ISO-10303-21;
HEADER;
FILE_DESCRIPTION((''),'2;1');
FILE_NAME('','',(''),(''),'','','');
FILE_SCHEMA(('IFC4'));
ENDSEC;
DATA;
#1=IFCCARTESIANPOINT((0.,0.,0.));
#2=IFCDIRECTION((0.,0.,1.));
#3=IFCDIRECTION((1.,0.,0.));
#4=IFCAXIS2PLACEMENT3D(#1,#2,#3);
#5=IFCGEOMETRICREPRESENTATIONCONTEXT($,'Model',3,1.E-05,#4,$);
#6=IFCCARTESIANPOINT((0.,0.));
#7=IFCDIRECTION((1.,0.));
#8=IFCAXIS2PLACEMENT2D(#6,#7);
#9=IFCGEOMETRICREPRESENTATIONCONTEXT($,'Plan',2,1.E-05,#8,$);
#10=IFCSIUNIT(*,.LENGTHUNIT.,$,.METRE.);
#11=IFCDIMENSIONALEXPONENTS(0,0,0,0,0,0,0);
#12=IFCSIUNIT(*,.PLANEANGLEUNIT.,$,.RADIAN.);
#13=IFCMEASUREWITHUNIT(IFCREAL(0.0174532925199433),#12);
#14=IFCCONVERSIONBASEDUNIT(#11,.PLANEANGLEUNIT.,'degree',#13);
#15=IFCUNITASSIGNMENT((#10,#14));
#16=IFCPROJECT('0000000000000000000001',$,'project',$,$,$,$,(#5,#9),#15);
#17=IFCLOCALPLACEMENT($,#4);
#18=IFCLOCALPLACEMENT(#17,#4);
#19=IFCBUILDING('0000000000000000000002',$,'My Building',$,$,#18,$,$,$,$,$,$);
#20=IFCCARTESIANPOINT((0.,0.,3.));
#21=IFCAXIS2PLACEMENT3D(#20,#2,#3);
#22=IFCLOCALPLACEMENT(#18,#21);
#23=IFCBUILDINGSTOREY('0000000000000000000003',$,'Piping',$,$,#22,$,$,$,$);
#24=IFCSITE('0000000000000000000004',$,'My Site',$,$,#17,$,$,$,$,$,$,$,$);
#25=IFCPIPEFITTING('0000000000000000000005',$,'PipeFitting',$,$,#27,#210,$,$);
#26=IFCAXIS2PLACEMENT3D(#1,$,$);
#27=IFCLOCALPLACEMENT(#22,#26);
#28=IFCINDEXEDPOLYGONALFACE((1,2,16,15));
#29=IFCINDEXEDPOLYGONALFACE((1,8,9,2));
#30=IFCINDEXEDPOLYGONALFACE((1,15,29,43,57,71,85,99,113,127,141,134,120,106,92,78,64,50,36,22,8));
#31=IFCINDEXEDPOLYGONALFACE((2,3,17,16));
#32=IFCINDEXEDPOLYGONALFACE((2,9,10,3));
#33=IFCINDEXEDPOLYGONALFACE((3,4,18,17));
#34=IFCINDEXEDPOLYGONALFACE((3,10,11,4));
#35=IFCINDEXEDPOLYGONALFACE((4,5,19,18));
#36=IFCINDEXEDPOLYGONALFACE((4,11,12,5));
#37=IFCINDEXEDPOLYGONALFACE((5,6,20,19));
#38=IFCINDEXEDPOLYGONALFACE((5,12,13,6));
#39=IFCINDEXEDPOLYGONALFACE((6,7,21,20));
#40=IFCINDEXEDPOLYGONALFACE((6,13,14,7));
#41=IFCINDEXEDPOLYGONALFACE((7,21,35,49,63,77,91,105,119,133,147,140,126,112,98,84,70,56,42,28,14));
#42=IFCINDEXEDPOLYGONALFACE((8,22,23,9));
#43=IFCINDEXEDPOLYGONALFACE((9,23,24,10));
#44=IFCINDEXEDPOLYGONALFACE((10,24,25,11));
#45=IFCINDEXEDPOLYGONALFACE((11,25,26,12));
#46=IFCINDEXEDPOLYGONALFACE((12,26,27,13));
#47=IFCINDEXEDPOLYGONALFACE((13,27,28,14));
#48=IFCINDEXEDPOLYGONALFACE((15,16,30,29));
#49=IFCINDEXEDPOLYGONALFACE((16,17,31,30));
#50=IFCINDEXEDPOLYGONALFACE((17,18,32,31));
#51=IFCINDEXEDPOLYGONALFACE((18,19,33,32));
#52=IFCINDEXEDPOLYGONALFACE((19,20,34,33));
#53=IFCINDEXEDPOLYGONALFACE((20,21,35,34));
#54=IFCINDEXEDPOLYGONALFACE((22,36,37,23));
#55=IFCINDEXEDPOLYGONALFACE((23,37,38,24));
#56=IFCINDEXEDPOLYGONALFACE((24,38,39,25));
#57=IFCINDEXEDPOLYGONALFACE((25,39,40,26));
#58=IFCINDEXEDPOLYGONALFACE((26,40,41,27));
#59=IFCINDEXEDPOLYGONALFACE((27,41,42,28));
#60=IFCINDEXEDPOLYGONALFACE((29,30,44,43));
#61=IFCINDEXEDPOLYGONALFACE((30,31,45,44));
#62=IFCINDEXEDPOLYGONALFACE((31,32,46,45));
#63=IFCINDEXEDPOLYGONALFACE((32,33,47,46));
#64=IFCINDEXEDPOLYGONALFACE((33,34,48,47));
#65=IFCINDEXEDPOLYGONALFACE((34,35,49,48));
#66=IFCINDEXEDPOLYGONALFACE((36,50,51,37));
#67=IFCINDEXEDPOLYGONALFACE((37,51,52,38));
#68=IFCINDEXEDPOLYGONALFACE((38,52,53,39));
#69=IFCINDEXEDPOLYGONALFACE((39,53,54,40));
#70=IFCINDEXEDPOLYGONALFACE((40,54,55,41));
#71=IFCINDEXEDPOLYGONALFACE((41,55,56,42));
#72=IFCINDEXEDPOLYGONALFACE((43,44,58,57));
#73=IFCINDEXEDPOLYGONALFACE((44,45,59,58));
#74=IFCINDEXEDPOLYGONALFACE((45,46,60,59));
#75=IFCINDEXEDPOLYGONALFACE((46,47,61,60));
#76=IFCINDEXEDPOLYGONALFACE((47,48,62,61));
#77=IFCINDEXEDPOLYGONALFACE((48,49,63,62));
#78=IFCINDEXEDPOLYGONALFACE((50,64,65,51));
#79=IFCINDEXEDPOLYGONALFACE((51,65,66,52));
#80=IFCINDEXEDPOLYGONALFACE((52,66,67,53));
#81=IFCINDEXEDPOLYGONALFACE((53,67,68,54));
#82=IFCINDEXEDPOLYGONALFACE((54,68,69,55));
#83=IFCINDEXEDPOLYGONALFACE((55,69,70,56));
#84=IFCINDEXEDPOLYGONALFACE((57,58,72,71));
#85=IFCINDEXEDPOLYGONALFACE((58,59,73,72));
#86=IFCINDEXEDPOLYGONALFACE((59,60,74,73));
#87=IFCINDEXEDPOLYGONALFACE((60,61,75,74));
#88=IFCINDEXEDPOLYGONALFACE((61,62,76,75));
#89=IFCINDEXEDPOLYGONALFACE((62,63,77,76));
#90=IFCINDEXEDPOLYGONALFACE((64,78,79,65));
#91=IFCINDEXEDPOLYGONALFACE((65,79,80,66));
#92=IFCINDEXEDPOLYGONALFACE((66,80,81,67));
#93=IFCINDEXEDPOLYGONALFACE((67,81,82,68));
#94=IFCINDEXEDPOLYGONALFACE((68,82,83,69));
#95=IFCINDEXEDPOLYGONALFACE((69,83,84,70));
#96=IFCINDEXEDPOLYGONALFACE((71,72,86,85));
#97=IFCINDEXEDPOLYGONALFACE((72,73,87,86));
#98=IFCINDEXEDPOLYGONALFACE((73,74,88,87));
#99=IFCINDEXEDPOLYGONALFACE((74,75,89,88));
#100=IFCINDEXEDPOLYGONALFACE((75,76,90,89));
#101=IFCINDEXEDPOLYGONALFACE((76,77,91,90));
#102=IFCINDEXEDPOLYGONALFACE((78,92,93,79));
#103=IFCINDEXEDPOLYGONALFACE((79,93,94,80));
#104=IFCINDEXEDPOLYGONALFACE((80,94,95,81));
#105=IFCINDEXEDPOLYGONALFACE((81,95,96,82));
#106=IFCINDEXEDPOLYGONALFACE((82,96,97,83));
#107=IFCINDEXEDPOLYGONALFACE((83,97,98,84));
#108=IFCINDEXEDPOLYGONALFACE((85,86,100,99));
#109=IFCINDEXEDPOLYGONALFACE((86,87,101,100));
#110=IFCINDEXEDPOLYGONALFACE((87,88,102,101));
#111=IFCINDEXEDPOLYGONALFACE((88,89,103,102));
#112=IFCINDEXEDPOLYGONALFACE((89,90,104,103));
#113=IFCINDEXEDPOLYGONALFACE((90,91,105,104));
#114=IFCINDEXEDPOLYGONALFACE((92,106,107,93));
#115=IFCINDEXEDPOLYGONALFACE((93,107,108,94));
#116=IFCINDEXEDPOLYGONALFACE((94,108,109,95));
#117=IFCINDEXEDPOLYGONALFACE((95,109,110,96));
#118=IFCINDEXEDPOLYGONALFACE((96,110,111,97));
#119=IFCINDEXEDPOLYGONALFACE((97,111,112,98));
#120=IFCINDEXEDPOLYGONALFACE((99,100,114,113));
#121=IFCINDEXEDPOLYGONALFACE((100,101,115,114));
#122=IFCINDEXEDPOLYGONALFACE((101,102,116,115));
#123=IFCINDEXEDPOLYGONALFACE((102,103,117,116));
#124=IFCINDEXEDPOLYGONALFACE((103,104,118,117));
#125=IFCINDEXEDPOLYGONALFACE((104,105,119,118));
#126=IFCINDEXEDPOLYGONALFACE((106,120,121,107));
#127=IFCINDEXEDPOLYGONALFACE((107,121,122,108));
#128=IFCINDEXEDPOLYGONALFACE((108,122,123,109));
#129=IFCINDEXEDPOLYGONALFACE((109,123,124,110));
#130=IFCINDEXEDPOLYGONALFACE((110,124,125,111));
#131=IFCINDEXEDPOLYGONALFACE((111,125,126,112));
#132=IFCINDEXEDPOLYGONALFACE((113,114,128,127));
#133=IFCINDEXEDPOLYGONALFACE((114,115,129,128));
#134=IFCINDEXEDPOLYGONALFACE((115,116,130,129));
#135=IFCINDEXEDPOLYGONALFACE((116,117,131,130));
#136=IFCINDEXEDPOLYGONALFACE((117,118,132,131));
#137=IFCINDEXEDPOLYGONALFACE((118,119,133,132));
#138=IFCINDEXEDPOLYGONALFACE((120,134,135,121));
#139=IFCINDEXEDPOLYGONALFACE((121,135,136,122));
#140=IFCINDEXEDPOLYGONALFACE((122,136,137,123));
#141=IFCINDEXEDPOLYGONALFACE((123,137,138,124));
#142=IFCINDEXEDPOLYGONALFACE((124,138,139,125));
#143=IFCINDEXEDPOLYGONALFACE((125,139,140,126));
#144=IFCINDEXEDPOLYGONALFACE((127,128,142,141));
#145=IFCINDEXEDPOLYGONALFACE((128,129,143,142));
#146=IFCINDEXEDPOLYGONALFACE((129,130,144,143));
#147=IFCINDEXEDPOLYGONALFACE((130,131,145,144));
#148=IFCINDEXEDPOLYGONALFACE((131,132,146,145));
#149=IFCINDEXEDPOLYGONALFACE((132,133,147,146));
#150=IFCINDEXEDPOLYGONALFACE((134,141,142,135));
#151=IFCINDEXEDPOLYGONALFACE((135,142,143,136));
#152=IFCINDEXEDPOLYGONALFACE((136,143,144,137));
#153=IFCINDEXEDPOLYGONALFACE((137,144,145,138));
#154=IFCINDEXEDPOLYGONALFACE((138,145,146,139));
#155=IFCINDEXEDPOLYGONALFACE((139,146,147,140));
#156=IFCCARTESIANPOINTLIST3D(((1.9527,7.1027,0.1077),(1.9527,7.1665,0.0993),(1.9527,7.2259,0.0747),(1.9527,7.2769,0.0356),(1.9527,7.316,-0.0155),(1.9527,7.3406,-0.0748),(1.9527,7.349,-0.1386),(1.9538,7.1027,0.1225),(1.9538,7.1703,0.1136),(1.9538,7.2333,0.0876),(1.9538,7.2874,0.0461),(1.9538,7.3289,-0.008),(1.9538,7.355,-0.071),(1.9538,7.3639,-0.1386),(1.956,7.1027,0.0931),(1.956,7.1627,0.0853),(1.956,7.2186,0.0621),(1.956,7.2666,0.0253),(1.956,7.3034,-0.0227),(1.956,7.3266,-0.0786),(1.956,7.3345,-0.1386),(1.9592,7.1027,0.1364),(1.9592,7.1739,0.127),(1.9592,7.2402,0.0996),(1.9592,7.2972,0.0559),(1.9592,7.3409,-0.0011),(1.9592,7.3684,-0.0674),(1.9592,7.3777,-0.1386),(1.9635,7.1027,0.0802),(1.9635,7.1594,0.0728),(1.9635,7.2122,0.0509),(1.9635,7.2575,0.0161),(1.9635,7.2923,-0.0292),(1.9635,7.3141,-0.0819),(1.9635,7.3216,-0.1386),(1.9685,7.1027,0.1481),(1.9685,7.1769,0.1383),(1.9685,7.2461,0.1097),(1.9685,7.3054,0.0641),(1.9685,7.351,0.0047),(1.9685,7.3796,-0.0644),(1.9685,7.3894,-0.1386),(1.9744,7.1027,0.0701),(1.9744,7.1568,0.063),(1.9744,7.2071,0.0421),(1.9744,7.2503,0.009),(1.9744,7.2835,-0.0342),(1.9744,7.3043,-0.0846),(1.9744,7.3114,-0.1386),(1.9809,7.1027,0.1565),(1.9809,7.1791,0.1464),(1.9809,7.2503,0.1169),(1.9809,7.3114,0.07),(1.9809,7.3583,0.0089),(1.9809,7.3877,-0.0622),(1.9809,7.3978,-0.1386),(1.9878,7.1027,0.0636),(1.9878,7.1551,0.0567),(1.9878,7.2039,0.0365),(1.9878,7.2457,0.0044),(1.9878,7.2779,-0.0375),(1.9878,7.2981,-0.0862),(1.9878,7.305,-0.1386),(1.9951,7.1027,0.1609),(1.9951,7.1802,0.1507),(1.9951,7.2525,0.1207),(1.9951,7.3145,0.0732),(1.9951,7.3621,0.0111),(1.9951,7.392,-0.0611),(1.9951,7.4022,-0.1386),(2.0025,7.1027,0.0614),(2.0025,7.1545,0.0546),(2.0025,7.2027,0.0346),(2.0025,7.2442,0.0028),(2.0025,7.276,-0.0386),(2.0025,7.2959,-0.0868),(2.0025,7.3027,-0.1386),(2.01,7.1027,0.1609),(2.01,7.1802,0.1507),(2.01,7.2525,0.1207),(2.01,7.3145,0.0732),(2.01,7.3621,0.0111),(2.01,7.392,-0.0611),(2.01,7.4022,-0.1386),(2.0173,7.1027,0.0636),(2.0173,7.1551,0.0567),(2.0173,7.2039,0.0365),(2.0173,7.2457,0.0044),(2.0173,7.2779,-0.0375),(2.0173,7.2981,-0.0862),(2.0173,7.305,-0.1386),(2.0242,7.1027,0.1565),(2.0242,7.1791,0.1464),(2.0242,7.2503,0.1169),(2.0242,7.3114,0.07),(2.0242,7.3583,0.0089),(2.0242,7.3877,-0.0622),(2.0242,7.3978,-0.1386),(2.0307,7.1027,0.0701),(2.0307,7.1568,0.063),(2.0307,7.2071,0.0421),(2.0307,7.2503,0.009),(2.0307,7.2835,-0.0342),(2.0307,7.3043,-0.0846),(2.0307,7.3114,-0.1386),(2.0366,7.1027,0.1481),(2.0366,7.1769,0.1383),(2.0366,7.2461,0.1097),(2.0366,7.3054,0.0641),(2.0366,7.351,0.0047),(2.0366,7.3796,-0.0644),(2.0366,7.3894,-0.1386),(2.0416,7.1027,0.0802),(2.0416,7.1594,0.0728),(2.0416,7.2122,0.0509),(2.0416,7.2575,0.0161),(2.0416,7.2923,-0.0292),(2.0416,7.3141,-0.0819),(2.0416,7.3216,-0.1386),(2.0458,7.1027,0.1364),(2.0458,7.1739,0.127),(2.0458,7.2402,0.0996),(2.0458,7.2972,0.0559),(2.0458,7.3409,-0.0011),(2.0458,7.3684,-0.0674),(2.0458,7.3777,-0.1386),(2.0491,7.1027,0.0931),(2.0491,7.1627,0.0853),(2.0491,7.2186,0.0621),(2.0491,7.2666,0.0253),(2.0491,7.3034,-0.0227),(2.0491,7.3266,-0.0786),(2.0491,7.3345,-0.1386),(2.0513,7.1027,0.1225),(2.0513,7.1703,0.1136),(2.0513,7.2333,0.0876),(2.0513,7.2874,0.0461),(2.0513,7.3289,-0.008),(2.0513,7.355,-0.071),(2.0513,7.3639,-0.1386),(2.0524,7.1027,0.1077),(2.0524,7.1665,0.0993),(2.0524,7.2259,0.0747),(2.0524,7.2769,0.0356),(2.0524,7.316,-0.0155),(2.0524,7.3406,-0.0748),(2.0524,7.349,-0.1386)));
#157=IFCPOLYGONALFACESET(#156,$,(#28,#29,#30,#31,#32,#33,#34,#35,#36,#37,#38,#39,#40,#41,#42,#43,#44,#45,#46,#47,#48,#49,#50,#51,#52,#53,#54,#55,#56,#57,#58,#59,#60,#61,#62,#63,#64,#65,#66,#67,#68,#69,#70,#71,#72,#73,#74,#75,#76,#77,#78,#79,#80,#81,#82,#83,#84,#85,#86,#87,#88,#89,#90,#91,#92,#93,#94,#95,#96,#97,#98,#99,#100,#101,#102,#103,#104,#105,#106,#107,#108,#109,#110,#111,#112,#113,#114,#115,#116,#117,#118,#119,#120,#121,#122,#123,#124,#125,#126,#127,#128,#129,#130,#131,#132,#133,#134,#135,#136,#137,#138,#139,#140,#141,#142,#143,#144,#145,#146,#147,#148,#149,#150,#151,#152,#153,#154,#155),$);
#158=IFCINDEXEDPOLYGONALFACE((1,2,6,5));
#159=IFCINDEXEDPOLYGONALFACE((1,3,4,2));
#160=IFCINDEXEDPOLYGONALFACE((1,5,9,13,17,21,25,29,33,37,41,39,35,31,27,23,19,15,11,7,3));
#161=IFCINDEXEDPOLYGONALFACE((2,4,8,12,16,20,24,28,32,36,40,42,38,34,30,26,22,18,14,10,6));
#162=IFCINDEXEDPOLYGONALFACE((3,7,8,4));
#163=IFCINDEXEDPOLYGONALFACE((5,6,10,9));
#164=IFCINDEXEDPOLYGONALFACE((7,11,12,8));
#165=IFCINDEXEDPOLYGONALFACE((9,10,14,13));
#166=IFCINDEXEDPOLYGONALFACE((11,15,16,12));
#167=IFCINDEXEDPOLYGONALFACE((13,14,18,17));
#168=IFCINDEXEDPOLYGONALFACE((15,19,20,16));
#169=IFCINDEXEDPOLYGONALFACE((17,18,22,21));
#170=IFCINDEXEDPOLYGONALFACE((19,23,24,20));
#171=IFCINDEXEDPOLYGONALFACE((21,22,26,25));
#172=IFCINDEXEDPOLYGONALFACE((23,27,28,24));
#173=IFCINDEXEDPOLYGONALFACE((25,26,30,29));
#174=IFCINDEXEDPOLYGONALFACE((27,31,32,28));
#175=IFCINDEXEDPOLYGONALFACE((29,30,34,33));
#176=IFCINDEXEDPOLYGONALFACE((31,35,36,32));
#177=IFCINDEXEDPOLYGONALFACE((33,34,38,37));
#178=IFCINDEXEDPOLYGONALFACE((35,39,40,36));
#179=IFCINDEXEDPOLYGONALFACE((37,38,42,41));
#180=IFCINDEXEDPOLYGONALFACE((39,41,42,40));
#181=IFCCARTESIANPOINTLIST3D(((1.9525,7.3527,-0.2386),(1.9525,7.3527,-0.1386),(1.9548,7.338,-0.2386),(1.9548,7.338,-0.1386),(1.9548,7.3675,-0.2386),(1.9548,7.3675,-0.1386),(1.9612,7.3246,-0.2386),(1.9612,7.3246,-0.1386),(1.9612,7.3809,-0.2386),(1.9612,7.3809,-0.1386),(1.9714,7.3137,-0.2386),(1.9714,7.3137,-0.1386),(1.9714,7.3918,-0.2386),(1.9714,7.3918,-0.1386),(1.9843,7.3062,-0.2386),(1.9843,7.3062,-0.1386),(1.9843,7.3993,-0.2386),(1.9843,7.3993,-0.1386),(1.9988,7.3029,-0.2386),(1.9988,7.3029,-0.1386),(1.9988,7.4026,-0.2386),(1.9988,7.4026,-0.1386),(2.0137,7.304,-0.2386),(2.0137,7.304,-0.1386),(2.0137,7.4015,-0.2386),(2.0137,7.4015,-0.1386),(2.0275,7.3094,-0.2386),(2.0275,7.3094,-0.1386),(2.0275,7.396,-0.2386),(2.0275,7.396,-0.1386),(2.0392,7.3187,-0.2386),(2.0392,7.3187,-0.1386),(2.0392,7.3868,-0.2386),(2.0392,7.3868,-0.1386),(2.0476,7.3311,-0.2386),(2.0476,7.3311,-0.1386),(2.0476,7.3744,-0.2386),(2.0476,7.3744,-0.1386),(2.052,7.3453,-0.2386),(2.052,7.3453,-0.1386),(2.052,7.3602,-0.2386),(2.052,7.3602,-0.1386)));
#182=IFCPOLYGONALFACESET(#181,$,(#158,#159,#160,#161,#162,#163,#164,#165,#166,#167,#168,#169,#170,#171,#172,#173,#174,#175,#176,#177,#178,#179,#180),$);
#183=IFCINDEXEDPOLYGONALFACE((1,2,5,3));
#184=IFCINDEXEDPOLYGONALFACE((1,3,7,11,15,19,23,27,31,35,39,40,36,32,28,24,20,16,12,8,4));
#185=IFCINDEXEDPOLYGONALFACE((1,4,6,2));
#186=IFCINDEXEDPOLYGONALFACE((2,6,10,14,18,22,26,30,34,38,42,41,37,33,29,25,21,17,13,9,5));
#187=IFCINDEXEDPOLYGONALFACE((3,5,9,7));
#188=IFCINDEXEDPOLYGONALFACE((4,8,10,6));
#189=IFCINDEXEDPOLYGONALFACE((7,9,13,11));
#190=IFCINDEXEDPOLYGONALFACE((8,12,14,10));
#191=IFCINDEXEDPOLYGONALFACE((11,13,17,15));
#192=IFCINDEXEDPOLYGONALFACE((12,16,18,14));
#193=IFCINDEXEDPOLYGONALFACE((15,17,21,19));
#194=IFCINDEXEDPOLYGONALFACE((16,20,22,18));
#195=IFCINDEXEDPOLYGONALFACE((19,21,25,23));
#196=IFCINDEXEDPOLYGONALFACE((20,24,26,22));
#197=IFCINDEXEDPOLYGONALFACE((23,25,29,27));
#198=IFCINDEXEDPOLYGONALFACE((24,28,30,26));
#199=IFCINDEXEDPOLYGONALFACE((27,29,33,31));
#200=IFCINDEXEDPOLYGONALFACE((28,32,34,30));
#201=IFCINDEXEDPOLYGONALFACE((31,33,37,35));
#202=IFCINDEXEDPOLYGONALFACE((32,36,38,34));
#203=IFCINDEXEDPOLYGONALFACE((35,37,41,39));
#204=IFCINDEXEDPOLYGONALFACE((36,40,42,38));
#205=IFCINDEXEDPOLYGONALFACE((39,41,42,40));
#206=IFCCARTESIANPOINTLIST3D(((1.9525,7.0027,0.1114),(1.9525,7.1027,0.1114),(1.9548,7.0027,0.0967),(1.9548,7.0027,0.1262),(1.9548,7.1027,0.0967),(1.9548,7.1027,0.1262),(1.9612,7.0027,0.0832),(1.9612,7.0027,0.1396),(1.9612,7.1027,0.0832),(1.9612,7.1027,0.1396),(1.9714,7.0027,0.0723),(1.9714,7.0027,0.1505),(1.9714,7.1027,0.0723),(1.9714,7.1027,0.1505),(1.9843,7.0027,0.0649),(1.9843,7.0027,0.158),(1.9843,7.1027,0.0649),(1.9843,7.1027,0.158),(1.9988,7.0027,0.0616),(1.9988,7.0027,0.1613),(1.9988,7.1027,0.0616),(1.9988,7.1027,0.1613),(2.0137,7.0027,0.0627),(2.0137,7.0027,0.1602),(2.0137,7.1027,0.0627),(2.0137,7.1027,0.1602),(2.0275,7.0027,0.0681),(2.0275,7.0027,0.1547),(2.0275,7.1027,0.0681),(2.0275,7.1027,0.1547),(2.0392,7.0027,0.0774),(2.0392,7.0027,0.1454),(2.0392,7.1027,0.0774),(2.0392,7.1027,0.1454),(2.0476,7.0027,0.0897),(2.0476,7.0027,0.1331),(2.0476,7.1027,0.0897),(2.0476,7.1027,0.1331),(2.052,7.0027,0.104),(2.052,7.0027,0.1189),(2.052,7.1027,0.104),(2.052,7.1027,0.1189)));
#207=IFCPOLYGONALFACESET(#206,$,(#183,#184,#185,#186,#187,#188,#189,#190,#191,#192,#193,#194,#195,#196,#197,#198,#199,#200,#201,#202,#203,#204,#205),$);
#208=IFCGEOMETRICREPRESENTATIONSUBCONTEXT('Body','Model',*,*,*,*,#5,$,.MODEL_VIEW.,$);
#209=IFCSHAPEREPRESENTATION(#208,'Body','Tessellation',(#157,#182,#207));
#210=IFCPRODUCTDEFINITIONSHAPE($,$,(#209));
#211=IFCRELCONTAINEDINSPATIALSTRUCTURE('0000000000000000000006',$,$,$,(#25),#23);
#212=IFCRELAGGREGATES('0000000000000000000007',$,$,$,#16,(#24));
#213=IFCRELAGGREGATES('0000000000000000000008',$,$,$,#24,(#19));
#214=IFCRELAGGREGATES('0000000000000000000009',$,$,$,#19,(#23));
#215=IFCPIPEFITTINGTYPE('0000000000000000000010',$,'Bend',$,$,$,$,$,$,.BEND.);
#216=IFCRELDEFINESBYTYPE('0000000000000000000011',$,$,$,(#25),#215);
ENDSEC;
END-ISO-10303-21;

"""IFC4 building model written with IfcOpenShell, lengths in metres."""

from ifc_helpers import new_model, entity, si_unit, converted_unit, frame, origin_with_axes, origin_2d_with_axis, place, context, subcontext, project, spatial, circle, extrude, source, transform, mapped, type_object, type_shapes, element, save


model = new_model("IFC4")

# Units and contexts
model_context = context("Model", 3, precision=1e-05, world=origin_with_axes())
plan_context = context("Plan", 2, precision=1e-05, world=origin_2d_with_axis())
body_context = subcontext(model_context, "Body", "Model", "MODEL_VIEW")
ifc_project = project(units=[si_unit("LENGTHUNIT", "METRE"), converted_unit("PLANEANGLEUNIT", "degree", entity("IfcReal", 0.0174532925199433), si_unit("PLANEANGLEUNIT", "RADIAN"), dimensions=[0, 0, 0, 0, 0, 0, 0])], contexts=[model_context, plan_context])

# Site, building, storey
site_placement = place(None, origin_with_axes())
site = spatial("IfcSite", under=ifc_project, at=site_placement, Name="My Site")
building_placement = place(site_placement, origin_with_axes())
building = spatial("IfcBuilding", under=site, at=building_placement, Name="My Building")
storey_placement = place(building_placement, frame((0.0, 0.0, 3.0), z_axis=(0.0, 0.0, 1.0), x_axis=(1.0, 0.0, 0.0)))
storey = spatial("IfcBuildingStorey", under=building, at=storey_placement, Name="Piping")

# Pipe fitting
pipe_fitting_type_1 = type_object("IfcPipeFittingType", Name="Bend", PredefinedType="BEND")
shared_shape = source(origin_with_axes(), body_context, "Body", "SolidModel", [
    entity("IfcSweptDiskSolid", entity("IfcIndexedPolyCurve", entity("IfcCartesianPointList3D", [[0.0, 0.0, -0.1], [0.0, -0.0732, -0.2768], [0.0, -0.25, -0.35]]), [entity("IfcArcIndex", [1, 2, 3])]), 0.05),
    extrude(circle(Radius=0.05), origin_with_axes(), (0.0, 0.0, -1.0), 0.1),
    extrude(circle(Radius=0.05), frame((0.0, -0.25, -0.35), z_axis=(0.0, -1.0, 0.0), x_axis=(1.0, 0.0, 0.0)), (0.0, 0.0, 1.0), 0.1),
])
type_shapes(pipe_fitting_type_1, [shared_shape])
for number, where, z_axis, x_axis, name in (
    (1, (2.0025, 7.3527, -0.2386), (0.0, 0.0, -1.0), (-1.0, 0.0, 0.0), "PipeFitting"),
):
    element("IfcPipeFitting", number, at=place(storey_placement, frame(where, z_axis=z_axis, x_axis=x_axis)), inside=storey, type_object=pipe_fitting_type_1, Name=name, context=body_context, shape_type="MappedRepresentation", body=[
        mapped(shared_shape, transform((0.0, 0.0, 0.0), x_axis=(1.0, 0.0, 0.0), y_axis=(0.0, 1.0, 0.0), z_axis=(0.0, 0.0, 1.0), scale=1.0)),
    ])

save(model, "model.ifc")
